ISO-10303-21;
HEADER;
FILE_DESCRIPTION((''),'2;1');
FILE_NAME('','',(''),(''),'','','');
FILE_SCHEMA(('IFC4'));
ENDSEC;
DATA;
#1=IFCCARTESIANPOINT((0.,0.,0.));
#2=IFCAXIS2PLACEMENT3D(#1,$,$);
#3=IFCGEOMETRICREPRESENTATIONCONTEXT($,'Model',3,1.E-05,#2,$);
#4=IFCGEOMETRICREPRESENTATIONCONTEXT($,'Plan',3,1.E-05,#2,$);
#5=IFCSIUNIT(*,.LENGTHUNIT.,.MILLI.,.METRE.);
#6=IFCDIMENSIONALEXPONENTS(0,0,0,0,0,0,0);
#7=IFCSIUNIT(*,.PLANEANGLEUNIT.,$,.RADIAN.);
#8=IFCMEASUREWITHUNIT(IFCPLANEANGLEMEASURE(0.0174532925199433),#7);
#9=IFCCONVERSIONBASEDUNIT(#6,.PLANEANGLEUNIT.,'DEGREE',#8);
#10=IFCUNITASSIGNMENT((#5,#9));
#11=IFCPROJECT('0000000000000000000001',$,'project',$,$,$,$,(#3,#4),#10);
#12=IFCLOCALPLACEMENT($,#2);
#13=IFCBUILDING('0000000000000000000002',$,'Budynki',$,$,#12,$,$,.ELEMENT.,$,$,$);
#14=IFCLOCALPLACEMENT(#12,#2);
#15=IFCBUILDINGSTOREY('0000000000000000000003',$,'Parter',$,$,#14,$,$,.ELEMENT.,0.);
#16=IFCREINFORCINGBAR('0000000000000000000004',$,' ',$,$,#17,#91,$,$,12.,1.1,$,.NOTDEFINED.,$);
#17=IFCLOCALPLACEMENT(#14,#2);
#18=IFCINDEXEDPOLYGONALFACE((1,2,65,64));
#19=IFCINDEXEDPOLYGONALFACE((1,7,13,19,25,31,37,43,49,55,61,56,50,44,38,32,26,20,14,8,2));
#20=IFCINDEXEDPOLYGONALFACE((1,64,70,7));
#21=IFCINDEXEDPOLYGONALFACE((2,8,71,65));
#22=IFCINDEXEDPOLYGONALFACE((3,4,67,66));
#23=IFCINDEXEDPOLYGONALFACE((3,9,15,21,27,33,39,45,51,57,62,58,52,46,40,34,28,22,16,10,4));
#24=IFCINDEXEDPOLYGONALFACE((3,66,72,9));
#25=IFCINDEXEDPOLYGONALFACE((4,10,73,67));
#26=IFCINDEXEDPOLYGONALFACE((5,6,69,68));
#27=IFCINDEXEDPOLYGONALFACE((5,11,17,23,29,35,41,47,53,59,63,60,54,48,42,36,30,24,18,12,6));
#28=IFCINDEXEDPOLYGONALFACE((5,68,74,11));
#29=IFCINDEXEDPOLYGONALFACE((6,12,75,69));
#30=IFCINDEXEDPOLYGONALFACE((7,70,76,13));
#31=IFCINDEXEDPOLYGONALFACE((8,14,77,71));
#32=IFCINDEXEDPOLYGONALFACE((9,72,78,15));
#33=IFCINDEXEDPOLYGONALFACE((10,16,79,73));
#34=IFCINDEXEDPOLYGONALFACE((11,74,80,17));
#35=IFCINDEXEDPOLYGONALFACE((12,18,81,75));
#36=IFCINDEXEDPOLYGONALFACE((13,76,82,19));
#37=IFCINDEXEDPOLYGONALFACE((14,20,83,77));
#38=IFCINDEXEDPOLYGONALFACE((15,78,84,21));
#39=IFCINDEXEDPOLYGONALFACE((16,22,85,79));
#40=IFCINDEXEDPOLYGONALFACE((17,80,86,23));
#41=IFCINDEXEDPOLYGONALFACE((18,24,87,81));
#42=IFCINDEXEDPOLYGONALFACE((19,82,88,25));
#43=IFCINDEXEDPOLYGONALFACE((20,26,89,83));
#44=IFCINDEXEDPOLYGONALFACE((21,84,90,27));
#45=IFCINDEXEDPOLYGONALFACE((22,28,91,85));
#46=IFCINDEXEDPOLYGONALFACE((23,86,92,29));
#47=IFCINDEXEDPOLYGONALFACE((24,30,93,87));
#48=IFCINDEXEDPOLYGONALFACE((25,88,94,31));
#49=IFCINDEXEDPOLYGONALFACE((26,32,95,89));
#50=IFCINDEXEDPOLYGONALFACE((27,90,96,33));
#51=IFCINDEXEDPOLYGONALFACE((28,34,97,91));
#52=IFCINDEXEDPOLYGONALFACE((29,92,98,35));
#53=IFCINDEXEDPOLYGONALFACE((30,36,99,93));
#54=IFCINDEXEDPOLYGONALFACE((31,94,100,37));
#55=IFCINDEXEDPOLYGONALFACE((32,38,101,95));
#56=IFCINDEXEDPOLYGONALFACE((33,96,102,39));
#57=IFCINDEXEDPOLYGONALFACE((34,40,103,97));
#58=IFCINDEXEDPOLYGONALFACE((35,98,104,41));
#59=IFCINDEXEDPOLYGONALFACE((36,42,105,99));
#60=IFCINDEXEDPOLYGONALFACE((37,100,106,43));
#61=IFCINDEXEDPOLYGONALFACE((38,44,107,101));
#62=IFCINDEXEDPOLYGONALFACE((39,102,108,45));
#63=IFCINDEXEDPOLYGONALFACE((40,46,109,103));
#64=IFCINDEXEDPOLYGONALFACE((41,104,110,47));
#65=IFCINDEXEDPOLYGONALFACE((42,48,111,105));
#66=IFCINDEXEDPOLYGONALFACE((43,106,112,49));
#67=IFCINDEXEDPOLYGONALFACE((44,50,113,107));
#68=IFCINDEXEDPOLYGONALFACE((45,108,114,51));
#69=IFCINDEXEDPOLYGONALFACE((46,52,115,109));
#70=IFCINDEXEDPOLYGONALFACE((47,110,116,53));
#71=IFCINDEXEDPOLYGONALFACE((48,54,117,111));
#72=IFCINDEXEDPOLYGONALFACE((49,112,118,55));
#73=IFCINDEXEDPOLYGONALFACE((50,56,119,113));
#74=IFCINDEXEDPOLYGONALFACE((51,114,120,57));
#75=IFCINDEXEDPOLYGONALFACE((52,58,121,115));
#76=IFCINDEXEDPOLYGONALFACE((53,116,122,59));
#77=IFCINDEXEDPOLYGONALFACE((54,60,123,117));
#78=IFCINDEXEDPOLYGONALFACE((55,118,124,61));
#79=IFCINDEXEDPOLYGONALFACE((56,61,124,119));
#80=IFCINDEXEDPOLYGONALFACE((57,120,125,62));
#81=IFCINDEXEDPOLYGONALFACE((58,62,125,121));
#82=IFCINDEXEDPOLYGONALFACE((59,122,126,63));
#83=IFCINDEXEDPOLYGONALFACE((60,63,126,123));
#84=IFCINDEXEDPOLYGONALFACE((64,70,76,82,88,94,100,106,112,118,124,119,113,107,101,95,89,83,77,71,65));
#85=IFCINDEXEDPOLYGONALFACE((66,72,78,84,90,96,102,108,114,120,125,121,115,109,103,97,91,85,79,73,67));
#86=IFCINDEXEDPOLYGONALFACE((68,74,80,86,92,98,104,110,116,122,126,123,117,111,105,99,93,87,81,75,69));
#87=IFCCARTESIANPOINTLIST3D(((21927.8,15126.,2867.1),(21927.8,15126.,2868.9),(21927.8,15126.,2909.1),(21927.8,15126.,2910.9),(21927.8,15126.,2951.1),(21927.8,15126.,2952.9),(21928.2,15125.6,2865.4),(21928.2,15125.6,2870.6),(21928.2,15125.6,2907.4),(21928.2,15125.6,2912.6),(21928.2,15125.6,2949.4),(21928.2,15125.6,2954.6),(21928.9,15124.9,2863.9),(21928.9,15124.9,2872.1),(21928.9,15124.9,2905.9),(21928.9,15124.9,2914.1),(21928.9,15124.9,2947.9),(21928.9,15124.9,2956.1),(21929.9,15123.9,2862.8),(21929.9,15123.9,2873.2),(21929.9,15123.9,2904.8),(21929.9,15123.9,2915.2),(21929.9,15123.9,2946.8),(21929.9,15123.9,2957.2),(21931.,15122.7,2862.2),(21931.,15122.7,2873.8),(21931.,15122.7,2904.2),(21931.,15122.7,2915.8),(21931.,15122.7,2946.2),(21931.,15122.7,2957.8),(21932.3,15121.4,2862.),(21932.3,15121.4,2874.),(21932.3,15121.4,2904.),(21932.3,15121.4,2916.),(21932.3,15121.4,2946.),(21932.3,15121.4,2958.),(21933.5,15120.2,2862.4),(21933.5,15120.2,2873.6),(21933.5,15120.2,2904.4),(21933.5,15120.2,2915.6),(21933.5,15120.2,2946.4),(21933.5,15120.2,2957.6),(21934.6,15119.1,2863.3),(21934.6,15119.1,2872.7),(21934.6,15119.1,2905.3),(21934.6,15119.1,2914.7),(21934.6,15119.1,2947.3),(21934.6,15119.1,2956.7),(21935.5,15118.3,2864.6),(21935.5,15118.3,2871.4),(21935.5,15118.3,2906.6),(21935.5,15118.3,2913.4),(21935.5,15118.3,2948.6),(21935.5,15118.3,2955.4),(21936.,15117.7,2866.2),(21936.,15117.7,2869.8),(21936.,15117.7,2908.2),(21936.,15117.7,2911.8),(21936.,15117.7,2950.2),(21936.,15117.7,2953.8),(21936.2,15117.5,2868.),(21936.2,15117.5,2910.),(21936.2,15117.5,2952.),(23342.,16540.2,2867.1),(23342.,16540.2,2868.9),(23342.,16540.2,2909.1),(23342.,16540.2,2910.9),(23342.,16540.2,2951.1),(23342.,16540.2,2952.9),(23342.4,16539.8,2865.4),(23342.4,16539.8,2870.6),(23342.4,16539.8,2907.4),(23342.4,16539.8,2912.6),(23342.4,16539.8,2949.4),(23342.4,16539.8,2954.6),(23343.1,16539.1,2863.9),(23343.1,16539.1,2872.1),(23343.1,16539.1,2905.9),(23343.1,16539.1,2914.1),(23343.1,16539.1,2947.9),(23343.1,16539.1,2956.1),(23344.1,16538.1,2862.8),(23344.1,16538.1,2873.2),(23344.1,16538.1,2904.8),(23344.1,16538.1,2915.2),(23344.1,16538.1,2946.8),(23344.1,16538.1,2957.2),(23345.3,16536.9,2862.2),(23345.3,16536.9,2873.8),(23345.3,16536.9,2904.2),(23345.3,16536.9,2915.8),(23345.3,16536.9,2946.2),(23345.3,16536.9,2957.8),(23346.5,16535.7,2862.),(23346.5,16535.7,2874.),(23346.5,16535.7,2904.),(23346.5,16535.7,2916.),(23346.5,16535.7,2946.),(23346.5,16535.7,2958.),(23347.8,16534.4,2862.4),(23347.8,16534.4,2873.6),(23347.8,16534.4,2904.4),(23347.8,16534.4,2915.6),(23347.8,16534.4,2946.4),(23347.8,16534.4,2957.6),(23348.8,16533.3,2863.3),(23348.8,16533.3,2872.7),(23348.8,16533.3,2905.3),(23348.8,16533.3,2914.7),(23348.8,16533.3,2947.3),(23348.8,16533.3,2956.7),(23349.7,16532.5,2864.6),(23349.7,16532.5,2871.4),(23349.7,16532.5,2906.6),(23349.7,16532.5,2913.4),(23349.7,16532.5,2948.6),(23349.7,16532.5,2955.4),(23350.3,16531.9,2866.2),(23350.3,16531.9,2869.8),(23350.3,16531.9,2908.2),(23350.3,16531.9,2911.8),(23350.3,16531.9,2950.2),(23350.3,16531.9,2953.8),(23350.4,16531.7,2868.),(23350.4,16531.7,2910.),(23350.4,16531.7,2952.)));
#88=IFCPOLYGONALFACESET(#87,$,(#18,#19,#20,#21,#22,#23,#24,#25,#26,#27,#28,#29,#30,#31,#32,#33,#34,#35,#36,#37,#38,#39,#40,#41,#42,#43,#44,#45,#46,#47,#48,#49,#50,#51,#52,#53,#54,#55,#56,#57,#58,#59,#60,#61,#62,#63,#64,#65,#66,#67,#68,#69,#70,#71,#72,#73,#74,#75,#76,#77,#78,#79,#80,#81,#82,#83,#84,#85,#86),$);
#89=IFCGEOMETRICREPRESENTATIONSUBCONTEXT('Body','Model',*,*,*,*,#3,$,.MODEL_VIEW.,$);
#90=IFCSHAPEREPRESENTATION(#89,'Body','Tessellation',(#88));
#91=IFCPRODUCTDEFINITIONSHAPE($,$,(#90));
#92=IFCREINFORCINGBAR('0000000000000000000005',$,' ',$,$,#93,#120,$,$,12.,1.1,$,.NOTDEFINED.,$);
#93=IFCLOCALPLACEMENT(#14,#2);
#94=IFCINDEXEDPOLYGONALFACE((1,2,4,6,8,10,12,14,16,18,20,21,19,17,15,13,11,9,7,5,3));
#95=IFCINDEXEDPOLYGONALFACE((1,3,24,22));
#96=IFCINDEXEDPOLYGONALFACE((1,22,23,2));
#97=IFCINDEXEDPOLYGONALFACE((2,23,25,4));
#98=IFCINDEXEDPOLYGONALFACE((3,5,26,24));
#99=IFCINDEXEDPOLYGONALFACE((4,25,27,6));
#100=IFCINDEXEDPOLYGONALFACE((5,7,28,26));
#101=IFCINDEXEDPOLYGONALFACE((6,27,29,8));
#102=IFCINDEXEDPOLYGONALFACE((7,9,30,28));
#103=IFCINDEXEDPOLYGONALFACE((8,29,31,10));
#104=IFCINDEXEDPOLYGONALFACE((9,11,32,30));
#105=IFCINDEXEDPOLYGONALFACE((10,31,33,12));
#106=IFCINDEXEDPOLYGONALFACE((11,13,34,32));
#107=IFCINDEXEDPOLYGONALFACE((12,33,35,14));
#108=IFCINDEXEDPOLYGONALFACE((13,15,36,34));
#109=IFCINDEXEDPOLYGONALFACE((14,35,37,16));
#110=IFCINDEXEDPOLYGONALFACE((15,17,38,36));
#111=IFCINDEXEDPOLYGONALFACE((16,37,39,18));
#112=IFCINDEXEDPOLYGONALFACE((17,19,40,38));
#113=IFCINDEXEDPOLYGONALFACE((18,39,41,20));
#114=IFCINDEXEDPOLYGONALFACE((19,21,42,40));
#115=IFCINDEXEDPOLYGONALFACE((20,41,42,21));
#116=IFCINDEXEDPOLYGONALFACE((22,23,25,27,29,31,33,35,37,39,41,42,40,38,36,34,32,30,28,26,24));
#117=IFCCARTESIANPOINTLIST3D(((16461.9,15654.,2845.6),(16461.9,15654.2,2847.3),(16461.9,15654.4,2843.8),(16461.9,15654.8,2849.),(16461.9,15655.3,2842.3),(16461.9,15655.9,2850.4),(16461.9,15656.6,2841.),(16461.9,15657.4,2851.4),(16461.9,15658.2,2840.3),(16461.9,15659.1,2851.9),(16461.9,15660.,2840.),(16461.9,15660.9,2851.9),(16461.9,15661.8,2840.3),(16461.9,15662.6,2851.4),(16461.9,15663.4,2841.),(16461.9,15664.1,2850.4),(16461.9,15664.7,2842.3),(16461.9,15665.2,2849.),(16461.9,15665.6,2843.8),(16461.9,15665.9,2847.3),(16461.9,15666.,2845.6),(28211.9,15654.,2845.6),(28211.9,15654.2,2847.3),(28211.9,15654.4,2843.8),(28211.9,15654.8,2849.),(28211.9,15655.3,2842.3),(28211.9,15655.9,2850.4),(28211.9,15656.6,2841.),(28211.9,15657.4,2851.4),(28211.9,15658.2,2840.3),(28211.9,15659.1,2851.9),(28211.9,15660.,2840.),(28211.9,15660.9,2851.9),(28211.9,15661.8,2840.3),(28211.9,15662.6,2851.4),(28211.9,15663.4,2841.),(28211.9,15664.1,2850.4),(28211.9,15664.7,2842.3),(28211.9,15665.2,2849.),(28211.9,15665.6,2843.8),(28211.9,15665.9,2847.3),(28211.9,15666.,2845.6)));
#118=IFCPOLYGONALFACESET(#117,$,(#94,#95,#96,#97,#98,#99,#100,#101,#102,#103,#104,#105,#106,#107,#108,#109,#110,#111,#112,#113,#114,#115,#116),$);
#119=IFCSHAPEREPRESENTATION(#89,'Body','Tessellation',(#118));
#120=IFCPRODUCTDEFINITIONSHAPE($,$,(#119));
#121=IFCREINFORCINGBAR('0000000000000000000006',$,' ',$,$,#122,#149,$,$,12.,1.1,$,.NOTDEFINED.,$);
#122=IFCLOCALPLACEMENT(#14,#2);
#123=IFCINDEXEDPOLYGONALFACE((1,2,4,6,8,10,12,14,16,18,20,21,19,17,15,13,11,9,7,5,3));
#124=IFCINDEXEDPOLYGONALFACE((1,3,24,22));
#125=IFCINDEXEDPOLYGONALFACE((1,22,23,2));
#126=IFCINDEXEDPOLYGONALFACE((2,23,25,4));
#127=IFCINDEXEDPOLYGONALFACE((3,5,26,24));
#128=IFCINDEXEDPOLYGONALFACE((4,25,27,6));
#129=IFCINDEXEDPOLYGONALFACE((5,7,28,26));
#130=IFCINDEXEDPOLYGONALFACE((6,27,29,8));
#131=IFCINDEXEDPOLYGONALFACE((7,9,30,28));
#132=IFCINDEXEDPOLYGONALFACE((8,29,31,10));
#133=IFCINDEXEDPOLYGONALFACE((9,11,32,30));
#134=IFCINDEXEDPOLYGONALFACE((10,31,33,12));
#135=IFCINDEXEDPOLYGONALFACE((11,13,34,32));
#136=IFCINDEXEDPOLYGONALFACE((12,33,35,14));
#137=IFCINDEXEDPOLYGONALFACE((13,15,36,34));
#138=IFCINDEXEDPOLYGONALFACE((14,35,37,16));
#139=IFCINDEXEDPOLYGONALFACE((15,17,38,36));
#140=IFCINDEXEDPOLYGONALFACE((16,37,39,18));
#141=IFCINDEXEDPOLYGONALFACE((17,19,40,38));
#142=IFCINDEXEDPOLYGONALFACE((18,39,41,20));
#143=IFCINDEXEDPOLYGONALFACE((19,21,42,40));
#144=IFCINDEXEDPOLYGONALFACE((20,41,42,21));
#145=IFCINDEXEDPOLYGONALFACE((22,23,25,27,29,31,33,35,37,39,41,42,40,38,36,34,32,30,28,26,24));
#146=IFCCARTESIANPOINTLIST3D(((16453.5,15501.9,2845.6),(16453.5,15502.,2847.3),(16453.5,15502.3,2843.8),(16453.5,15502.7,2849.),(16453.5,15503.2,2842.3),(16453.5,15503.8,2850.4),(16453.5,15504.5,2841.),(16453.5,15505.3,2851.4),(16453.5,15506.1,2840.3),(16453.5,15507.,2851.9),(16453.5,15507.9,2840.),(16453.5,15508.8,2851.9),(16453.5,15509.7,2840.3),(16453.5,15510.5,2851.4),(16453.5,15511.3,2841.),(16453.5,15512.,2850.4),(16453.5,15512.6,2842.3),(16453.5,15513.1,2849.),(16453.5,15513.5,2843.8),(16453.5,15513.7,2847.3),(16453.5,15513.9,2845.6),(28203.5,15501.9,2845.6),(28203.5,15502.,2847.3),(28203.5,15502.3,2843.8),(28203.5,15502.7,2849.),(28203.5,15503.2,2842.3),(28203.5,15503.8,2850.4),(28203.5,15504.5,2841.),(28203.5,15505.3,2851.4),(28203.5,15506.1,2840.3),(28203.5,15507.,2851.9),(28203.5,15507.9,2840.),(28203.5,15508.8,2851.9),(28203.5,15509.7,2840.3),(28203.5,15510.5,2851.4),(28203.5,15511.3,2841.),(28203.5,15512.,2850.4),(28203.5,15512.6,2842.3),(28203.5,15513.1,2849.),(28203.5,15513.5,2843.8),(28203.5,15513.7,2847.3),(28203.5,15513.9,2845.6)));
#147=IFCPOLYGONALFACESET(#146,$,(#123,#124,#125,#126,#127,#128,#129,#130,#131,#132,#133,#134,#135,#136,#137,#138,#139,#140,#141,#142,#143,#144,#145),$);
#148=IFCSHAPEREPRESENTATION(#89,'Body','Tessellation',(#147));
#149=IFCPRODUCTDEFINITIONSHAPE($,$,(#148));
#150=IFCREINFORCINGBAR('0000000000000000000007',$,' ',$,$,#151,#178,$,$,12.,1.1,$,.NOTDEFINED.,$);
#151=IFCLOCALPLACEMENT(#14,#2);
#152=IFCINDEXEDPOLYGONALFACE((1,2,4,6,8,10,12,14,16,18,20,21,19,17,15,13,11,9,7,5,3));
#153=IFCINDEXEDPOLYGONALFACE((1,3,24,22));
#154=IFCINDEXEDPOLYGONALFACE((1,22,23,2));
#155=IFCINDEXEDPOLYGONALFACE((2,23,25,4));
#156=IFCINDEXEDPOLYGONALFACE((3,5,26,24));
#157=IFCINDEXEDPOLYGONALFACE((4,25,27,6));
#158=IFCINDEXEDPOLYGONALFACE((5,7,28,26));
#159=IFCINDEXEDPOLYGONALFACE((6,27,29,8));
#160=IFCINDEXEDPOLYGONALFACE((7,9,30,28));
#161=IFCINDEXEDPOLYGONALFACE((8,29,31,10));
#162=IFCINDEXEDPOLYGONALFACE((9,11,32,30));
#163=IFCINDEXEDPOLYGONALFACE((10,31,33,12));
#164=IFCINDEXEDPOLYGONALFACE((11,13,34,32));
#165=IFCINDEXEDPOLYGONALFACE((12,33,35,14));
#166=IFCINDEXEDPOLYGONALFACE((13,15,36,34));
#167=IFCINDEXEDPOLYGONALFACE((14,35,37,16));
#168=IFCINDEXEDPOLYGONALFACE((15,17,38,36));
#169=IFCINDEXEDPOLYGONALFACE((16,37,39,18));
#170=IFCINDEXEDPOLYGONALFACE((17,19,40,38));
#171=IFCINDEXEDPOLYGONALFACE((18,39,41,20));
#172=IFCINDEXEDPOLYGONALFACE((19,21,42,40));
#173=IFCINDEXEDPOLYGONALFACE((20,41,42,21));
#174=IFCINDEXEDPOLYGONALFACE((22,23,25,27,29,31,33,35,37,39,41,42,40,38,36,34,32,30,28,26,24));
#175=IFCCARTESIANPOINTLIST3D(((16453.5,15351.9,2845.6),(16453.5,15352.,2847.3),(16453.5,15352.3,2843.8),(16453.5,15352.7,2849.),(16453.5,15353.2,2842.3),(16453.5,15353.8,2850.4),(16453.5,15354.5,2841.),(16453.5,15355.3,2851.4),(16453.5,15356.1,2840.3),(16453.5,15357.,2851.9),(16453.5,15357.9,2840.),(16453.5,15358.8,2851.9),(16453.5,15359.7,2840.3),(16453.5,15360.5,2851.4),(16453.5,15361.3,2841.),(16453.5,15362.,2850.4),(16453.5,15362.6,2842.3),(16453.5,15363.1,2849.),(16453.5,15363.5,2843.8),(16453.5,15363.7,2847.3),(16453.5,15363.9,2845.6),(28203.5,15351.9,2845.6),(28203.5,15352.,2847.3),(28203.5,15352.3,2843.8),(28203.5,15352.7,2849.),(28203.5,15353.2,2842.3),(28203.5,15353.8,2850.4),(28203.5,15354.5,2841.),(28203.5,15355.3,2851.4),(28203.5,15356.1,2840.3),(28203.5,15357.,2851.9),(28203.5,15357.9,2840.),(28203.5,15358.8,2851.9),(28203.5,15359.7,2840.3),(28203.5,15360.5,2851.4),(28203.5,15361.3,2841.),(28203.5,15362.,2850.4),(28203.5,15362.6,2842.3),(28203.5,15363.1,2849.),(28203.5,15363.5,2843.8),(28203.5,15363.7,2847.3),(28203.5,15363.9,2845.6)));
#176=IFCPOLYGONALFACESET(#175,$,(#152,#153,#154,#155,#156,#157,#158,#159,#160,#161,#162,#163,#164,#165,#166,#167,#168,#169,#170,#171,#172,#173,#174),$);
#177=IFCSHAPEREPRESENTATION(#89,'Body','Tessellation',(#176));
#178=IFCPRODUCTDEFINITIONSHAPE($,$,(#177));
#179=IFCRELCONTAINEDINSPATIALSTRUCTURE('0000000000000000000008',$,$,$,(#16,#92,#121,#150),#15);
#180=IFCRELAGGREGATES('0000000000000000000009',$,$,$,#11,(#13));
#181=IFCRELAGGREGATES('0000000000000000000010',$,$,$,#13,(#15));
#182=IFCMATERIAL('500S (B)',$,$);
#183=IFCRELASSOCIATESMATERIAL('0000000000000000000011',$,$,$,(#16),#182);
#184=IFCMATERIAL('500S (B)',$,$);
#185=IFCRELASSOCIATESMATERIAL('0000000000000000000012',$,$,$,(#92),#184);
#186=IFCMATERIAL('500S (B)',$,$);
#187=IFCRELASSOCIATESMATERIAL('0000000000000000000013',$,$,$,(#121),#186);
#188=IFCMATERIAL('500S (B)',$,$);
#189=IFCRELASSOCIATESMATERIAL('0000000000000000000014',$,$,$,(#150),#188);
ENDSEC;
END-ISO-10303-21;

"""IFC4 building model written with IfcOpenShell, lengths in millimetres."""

from ifc_helpers import new_model, entity, si_unit, converted_unit, frame, origin, origin_with_axes, place, context, subcontext, project, spatial, source, transform, mapped, material, element, save


model = new_model("IFC4")

# Units and contexts
model_context = context("Model", 3, precision=1e-05, world=origin())
plan_context = context("Plan", 3, precision=1e-05, world=origin())
body_context = subcontext(model_context, "Body", "Model", "MODEL_VIEW")
ifc_project = project(units=[si_unit("LENGTHUNIT", "METRE", prefix="MILLI"), converted_unit("PLANEANGLEUNIT", "DEGREE", entity("IfcPlaneAngleMeasure", 0.0174532925199433), si_unit("PLANEANGLEUNIT", "RADIAN"), dimensions=[0, 0, 0, 0, 0, 0, 0])], contexts=[model_context, plan_context])

# Building, storey
building_placement = place(None, origin())
building = spatial("IfcBuilding", under=ifc_project, at=building_placement, Name="Budynki", CompositionType="ELEMENT")
storey_placement = place(building_placement, origin())
storey = spatial("IfcBuildingStorey", under=building, at=storey_placement, Name="Parter", CompositionType="ELEMENT", Elevation=0.0)

# Reinforcing bars
ifc_material_1 = material(Name="500S (B)")
shared_shape_1 = source(origin_with_axes(), body_context, "Body", "AdvancedSweptSolid", [
    entity("IfcSweptDiskSolid", entity("IfcPolyline", [entity("IfcCartesianPoint", [0.0, 0.0, 0.0]), entity("IfcCartesianPoint", [-1414.2, -1414.2, 0.0])]), 6.0, None, 0.0, 1.0),
])
reinforcing_bar_1_placement = place(storey_placement, frame((23346.2, 16536.0, 2868.0)))
element("IfcReinforcingBar", 1, at=reinforcing_bar_1_placement, inside=storey, material=ifc_material_1, Name=" ", CrossSectionArea=1.1, NominalDiameter=12.0, PredefinedType="NOTDEFINED", context=body_context, shape_type="MappedRepresentation", body=[
    mapped(shared_shape_1, transform((0.0, 0.0, 0.0), y_axis=(0.0, 1.0, 0.0), scale=1.0)),
    mapped(shared_shape_1, transform((0.0, 0.0, 42.0), y_axis=(0.0, 1.0, 0.0), scale=1.0)),
    mapped(shared_shape_1, transform((0.0, 0.0, 84.0), y_axis=(0.0, 1.0, 0.0), scale=1.0)),
])
ifc_material_2 = material(Name="500S (B)")
reinforcing_bar_2_placement = place(storey_placement, frame((28211.9, 15660.0, 2846.0)))
element("IfcReinforcingBar", 2, at=reinforcing_bar_2_placement, inside=storey, material=ifc_material_2, Name=" ", CrossSectionArea=1.1, NominalDiameter=12.0, PredefinedType="NOTDEFINED", context=body_context, shape_type="AdvancedSweptSolid", body=[
    entity("IfcSweptDiskSolid", entity("IfcPolyline", [entity("IfcCartesianPoint", [0.0, 0.0, 0.0]), entity("IfcCartesianPoint", [-11750.0, 0.0, 0.0])]), 6.0, None, 0.0, 1.0),
])
ifc_material_3 = material(Name="500S (B)")
reinforcing_bar_3_placement = place(storey_placement, frame((28203.5, 15507.9, 2846.0)))
element("IfcReinforcingBar", 3, at=reinforcing_bar_3_placement, inside=storey, material=ifc_material_3, Name=" ", CrossSectionArea=1.1, NominalDiameter=12.0, PredefinedType="NOTDEFINED", context=body_context, shape_type="AdvancedSweptSolid", body=[
    entity("IfcSweptDiskSolid", entity("IfcPolyline", [entity("IfcCartesianPoint", [0.0, 0.0, 0.0]), entity("IfcCartesianPoint", [-11750.0, 0.0, 0.0])]), 6.0, None, 0.0, 1.0),
])
ifc_material_4 = material(Name="500S (B)")
reinforcing_bar_4_placement = place(storey_placement, frame((28203.5, 15357.9, 2846.0)))
element("IfcReinforcingBar", 4, at=reinforcing_bar_4_placement, inside=storey, material=ifc_material_4, Name=" ", CrossSectionArea=1.1, NominalDiameter=12.0, PredefinedType="NOTDEFINED", context=body_context, shape_type="AdvancedSweptSolid", body=[
    entity("IfcSweptDiskSolid", entity("IfcPolyline", [entity("IfcCartesianPoint", [0.0, 0.0, 0.0]), entity("IfcCartesianPoint", [-11750.0, 0.0, 0.0])]), 6.0, None, 0.0, 1.0),
])

save(model, "model.ifc")
